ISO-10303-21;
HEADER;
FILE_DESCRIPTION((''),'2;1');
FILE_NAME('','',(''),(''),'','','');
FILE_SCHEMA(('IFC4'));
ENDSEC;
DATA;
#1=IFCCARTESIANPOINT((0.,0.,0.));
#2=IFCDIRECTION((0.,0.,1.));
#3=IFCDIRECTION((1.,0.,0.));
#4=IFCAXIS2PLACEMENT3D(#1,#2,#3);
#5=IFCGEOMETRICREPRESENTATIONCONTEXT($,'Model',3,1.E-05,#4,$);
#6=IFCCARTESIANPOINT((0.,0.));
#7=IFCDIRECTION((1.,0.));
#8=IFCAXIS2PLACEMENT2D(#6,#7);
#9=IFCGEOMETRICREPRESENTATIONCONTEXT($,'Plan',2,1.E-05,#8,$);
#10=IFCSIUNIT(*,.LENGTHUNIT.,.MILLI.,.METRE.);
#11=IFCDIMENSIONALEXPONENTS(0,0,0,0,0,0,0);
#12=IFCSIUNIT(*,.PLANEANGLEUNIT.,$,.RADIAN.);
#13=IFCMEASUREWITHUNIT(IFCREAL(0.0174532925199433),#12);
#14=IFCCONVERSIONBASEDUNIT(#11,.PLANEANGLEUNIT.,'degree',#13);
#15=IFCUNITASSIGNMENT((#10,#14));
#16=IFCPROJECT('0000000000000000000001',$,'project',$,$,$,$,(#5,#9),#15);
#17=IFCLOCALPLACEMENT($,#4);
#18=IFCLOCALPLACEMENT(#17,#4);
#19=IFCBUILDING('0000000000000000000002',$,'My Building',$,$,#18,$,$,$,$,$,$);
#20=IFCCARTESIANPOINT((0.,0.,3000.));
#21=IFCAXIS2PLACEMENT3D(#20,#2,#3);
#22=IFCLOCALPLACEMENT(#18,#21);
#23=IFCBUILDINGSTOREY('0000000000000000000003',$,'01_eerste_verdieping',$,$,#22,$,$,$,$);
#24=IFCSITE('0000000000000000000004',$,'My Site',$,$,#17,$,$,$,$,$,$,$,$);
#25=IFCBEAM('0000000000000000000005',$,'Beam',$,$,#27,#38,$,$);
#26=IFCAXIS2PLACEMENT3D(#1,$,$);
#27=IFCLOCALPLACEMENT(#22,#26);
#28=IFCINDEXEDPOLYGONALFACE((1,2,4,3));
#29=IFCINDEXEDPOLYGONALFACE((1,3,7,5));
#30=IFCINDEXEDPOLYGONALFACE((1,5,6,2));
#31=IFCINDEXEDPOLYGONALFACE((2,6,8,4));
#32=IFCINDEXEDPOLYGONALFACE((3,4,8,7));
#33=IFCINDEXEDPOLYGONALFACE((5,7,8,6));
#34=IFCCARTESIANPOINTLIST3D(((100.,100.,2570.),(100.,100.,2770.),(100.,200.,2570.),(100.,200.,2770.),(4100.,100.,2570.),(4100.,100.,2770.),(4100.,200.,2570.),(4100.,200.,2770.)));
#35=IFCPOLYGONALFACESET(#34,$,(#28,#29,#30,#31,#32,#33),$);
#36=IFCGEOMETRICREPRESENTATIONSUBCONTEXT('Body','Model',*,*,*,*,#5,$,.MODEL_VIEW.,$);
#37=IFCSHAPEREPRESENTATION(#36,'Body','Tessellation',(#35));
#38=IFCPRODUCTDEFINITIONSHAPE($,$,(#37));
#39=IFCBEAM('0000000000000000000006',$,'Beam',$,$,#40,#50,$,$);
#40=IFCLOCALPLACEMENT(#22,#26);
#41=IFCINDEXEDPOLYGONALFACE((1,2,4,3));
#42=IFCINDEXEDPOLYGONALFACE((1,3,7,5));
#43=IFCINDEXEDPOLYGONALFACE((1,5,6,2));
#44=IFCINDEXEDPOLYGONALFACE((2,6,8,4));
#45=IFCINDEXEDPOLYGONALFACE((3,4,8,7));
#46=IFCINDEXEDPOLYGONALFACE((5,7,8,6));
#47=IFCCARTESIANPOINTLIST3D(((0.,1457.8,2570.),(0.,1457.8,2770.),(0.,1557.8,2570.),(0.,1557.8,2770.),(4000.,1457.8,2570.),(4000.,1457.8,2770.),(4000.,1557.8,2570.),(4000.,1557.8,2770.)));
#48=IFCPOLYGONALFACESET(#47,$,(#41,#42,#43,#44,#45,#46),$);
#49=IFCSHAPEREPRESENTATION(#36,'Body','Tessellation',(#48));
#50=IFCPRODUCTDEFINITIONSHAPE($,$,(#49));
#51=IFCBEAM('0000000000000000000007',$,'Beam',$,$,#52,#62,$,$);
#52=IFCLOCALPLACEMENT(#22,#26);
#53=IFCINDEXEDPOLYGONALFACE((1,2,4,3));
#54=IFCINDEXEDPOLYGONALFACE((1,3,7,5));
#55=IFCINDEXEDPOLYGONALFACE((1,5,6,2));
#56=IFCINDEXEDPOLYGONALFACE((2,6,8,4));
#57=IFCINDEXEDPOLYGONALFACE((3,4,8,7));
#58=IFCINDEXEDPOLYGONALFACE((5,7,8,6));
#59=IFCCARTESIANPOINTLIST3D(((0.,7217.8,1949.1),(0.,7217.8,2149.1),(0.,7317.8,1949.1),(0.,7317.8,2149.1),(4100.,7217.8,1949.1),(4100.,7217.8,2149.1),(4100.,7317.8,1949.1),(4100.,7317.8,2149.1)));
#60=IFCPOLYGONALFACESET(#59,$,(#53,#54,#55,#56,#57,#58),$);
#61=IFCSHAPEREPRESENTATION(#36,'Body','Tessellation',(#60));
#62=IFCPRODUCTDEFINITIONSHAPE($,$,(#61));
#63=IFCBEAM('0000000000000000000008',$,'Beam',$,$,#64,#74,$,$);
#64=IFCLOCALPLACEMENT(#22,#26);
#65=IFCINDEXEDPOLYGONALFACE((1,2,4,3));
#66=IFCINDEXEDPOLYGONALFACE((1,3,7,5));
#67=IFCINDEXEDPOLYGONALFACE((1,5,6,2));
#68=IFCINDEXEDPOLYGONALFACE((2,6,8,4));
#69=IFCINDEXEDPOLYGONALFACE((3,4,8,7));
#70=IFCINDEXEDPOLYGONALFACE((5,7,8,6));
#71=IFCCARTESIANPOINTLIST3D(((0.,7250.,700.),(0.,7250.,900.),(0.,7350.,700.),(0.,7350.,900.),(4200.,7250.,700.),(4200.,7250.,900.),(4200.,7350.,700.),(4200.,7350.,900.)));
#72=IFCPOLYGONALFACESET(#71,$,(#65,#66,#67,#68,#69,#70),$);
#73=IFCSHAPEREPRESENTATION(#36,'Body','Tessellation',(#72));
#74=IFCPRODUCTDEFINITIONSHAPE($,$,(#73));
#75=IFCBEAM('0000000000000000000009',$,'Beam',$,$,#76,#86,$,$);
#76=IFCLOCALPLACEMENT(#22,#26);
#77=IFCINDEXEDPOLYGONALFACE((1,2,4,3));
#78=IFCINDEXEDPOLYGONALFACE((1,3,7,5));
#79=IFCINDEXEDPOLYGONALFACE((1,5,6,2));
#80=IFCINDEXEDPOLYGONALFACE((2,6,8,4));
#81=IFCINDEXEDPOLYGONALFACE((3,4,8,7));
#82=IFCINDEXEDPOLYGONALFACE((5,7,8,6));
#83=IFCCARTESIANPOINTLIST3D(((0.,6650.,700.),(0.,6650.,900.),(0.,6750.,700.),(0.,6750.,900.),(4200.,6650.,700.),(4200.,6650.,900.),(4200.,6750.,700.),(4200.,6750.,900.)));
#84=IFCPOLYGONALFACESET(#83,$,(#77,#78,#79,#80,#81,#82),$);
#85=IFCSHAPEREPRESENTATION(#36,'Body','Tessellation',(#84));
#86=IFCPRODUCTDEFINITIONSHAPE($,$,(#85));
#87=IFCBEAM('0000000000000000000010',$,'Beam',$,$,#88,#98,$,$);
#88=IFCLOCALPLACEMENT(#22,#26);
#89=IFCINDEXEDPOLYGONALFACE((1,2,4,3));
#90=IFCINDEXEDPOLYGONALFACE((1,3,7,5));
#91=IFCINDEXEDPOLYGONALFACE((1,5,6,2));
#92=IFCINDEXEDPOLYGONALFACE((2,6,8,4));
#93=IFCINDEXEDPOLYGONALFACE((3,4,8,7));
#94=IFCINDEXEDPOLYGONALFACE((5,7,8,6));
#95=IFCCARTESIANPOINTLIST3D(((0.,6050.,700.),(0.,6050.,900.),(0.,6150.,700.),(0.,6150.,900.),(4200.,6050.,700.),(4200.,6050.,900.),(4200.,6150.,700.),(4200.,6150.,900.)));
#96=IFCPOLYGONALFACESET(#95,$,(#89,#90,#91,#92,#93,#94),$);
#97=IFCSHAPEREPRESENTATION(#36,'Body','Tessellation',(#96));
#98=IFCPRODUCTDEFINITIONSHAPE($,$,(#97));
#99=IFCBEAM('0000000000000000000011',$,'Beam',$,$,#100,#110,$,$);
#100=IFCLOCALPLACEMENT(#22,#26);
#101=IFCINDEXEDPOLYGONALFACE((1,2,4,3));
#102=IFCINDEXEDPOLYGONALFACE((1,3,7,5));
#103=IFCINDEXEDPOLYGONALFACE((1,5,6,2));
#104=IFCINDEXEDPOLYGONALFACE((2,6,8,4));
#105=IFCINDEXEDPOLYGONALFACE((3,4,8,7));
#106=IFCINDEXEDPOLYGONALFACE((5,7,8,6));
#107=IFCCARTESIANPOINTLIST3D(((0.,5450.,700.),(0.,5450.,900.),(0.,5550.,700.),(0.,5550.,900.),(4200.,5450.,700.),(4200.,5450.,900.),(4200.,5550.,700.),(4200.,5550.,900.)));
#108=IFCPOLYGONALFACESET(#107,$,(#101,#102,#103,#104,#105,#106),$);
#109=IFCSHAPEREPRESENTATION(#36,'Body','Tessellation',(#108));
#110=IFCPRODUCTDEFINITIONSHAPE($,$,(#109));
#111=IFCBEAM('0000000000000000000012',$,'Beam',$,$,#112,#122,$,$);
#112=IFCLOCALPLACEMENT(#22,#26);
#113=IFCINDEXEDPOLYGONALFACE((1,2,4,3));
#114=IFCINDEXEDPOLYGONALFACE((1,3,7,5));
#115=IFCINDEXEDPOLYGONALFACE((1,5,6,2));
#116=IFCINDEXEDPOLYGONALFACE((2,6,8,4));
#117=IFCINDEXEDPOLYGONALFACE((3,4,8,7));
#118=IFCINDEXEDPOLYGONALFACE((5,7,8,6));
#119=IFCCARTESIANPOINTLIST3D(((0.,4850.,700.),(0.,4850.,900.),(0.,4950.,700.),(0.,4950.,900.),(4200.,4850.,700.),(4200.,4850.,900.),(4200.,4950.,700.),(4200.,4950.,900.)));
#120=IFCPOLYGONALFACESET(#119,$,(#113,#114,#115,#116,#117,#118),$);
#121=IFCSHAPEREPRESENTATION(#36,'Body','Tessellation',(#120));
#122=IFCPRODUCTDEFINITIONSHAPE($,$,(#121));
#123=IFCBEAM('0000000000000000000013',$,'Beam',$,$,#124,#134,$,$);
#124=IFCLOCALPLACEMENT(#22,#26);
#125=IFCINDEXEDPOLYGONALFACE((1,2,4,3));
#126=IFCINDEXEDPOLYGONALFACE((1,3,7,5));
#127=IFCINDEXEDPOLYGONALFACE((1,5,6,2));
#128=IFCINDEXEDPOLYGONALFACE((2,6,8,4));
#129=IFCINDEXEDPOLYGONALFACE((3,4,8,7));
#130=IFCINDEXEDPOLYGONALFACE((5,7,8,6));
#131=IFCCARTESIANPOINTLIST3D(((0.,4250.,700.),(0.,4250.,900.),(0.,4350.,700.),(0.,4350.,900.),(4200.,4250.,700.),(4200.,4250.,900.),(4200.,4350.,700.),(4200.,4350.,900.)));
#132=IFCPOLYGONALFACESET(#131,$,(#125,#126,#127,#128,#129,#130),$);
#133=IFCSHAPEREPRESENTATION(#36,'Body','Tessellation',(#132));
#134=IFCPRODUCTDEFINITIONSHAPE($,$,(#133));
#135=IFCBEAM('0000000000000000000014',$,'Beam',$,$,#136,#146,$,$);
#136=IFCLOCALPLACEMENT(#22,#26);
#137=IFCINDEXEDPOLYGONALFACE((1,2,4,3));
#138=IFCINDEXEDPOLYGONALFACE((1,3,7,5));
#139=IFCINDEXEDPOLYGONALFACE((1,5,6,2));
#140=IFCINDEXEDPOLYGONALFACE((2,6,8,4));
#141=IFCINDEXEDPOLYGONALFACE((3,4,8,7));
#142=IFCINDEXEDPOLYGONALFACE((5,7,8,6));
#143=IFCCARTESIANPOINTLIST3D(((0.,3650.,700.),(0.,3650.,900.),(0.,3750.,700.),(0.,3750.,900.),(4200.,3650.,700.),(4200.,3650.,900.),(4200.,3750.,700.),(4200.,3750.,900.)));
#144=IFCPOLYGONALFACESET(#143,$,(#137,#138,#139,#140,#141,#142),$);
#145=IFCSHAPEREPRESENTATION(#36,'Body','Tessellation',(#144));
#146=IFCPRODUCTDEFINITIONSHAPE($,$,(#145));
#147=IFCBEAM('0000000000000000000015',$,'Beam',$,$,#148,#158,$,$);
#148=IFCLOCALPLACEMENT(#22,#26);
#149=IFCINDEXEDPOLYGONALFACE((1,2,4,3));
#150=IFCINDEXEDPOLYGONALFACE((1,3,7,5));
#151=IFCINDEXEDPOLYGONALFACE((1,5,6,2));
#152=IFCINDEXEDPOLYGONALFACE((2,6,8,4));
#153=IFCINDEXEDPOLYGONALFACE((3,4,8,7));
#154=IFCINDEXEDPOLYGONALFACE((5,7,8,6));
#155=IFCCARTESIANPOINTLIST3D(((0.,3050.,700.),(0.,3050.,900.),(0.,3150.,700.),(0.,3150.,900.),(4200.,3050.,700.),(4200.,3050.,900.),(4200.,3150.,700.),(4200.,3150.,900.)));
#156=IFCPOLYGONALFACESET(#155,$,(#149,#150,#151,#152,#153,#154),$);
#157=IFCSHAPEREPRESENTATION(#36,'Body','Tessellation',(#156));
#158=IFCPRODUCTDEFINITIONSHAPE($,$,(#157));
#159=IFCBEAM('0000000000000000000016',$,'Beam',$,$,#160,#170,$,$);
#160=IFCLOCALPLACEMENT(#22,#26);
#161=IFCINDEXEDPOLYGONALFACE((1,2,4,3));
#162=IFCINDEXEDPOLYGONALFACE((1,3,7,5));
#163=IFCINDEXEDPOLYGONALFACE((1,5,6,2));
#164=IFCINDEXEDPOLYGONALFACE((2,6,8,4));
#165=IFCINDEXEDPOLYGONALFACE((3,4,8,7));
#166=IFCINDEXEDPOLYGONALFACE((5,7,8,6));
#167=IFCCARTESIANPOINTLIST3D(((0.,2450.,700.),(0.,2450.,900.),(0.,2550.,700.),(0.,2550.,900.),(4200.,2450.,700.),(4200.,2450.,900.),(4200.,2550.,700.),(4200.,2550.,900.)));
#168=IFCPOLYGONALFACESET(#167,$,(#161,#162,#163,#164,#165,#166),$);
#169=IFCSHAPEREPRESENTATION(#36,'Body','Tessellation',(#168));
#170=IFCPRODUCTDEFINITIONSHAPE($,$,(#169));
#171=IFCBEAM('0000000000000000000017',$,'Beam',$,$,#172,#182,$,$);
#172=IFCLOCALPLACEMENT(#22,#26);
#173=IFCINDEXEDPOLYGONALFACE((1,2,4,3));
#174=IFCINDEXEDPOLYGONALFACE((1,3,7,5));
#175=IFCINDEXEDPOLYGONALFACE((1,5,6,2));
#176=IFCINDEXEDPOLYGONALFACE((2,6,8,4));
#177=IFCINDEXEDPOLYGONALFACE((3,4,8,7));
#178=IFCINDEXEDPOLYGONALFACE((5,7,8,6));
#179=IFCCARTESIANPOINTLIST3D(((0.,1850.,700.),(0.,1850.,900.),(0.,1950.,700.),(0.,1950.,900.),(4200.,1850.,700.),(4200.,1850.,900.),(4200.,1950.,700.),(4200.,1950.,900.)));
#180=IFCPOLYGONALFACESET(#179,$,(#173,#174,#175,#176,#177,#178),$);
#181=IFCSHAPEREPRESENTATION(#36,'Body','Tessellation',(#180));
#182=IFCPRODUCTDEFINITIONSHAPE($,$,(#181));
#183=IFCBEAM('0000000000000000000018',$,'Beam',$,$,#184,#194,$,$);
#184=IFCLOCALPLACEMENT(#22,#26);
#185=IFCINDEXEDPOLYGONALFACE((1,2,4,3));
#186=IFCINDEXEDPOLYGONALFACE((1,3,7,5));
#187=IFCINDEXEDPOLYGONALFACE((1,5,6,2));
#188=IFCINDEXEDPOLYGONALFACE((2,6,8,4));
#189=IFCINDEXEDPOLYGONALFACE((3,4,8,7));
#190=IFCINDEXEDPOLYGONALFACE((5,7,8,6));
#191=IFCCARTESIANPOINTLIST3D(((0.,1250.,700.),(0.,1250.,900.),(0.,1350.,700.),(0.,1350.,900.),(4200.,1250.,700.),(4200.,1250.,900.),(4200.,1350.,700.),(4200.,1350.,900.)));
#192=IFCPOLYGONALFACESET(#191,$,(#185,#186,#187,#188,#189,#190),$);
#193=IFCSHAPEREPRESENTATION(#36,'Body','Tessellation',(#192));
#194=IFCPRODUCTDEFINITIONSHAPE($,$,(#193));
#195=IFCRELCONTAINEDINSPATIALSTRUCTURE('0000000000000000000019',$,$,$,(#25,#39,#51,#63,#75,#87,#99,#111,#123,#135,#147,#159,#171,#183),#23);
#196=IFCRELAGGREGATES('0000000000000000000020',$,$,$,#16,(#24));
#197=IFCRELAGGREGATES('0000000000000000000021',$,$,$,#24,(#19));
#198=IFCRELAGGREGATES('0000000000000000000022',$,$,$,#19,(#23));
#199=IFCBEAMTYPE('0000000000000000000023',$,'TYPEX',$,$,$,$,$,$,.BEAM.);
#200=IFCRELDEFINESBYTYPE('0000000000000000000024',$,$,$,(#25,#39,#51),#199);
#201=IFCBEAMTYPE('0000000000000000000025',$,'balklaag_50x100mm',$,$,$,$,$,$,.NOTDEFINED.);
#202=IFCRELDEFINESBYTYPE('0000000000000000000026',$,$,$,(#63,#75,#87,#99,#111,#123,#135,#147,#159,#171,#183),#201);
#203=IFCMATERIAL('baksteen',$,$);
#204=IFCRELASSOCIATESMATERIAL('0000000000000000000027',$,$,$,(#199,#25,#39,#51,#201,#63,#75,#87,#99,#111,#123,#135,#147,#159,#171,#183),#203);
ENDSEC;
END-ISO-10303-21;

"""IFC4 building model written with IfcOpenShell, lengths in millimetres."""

from ifc_helpers import new_model, entity, si_unit, converted_unit, frame, origin_with_axes, origin_2d_with_axis, place, context, subcontext, project, spatial, rectangle, extrude, material, material_profile, profile_set, profile_usage, type_object, element, save


model = new_model("IFC4")

# Units and contexts
model_context = context("Model", 3, precision=1e-05, world=origin_with_axes())
plan_context = context("Plan", 2, precision=1e-05, world=origin_2d_with_axis())
body_context = subcontext(model_context, "Body", "Model", "MODEL_VIEW")
ifc_project = project(units=[si_unit("LENGTHUNIT", "METRE", prefix="MILLI"), converted_unit("PLANEANGLEUNIT", "degree", entity("IfcReal", 0.0174532925199433), si_unit("PLANEANGLEUNIT", "RADIAN"), dimensions=[0, 0, 0, 0, 0, 0, 0])], contexts=[model_context, plan_context])

# Site, building, storey
site_placement = place(None, origin_with_axes())
site = spatial("IfcSite", under=ifc_project, at=site_placement, Name="My Site")
building_placement = place(site_placement, origin_with_axes())
building = spatial("IfcBuilding", under=site, at=building_placement, Name="My Building")
storey_placement = place(building_placement, frame((0.0, 0.0, 3000.0), z_axis=(0.0, 0.0, 1.0), x_axis=(1.0, 0.0, 0.0)))
storey = spatial("IfcBuildingStorey", under=building, at=storey_placement, Name="01_eerste_verdieping")

# Beams
ifc_material = material(Name="baksteen")
ifc_material_profile_1 = material_profile(ifc_material, rectangle(XDim=100.0, YDim=200.0))
ifc_profile_set_1 = profile_set([ifc_material_profile_1])
ifc_profile_usage_1 = profile_usage(ifc_profile_set_1, cardinal=5)
beam_type_1 = type_object("IfcBeamType", Name="TYPEX", PredefinedType="BEAM", material=ifc_profile_set_1)
beam_1_placement = place(storey_placement, frame((100.0, 150.0, 2670.0), z_axis=(1.0, 0.0, 0.0), x_axis=(0.0, 1.0, 0.0)))
element("IfcBeam", 1, at=beam_1_placement, inside=storey, type_object=beam_type_1, material=ifc_profile_usage_1, Name="Beam", context=body_context, shape_type="SweptSolid", body=[
    extrude(rectangle(XDim=100.0, YDim=200.0), origin_with_axes(), (0.0, 0.0, 1.0), 4000.0),
])
ifc_profile_usage_2 = profile_usage(ifc_profile_set_1, cardinal=5)
beam_2_placement = place(storey_placement, frame((0.0, 1507.8, 2670.0), z_axis=(1.0, 0.0, 0.0), x_axis=(0.0, 1.0, 0.0)))
element("IfcBeam", 2, at=beam_2_placement, inside=storey, type_object=beam_type_1, material=ifc_profile_usage_2, Name="Beam", context=body_context, shape_type="SweptSolid", body=[
    extrude(rectangle(XDim=100.0, YDim=200.0), origin_with_axes(), (0.0, 0.0, 1.0), 4000.0),
])
ifc_profile_usage_3 = profile_usage(ifc_profile_set_1, cardinal=5)
beam_3_placement = place(storey_placement, frame((0.0, 7267.8, 2049.1), z_axis=(1.0, 0.0, 0.0), x_axis=(0.0, 1.0, 0.0)))
element("IfcBeam", 3, at=beam_3_placement, inside=storey, type_object=beam_type_1, material=ifc_profile_usage_3, Name="Beam", context=body_context, shape_type="SweptSolid", body=[
    extrude(rectangle(XDim=100.0, YDim=200.0), origin_with_axes(), (0.0, 0.0, 1.0), 4100.0),
])
ifc_material_profile_2 = material_profile(ifc_material, rectangle(XDim=100.0, YDim=200.0))
ifc_profile_set_2 = profile_set([ifc_material_profile_2])
ifc_profile_usage_4 = profile_usage(ifc_profile_set_2, cardinal=5)
beam_type_2 = type_object("IfcBeamType", Name="balklaag_50x100mm", PredefinedType="NOTDEFINED", material=ifc_profile_set_2)
beam_4_placement = place(storey_placement, frame((4200.0, 7300.0, 800.0), z_axis=(-1.0, 0.0, 0.0), x_axis=(0.0, -1.0, 0.0)))
element("IfcBeam", 4, at=beam_4_placement, inside=storey, type_object=beam_type_2, material=ifc_profile_usage_4, Name="Beam", context=body_context, shape_type="SweptSolid", body=[
    extrude(rectangle(XDim=100.0, YDim=200.0), origin_with_axes(), (0.0, 0.0, 1.0), 4200.0),
])
ifc_profile_usage_5 = profile_usage(ifc_profile_set_2, cardinal=5)
beam_5_placement = place(storey_placement, frame((4200.0, 6700.0, 800.0), z_axis=(-1.0, 0.0, 0.0), x_axis=(0.0, -1.0, 0.0)))
element("IfcBeam", 5, at=beam_5_placement, inside=storey, type_object=beam_type_2, material=ifc_profile_usage_5, Name="Beam", context=body_context, shape_type="SweptSolid", body=[
    extrude(rectangle(XDim=100.0, YDim=200.0), origin_with_axes(), (0.0, 0.0, 1.0), 4200.0),
])
ifc_profile_usage_6 = profile_usage(ifc_profile_set_2, cardinal=5)
beam_6_placement = place(storey_placement, frame((4200.0, 6100.0, 800.0), z_axis=(-1.0, 0.0, 0.0), x_axis=(0.0, -1.0, 0.0)))
element("IfcBeam", 6, at=beam_6_placement, inside=storey, type_object=beam_type_2, material=ifc_profile_usage_6, Name="Beam", context=body_context, shape_type="SweptSolid", body=[
    extrude(rectangle(XDim=100.0, YDim=200.0), origin_with_axes(), (0.0, 0.0, 1.0), 4200.0),
])
ifc_profile_usage_7 = profile_usage(ifc_profile_set_2, cardinal=5)
beam_7_placement = place(storey_placement, frame((4200.0, 5500.0, 800.0), z_axis=(-1.0, 0.0, 0.0), x_axis=(0.0, -1.0, 0.0)))
element("IfcBeam", 7, at=beam_7_placement, inside=storey, type_object=beam_type_2, material=ifc_profile_usage_7, Name="Beam", context=body_context, shape_type="SweptSolid", body=[
    extrude(rectangle(XDim=100.0, YDim=200.0), origin_with_axes(), (0.0, 0.0, 1.0), 4200.0),
])
ifc_profile_usage_8 = profile_usage(ifc_profile_set_2, cardinal=5)
beam_8_placement = place(storey_placement, frame((4200.0, 4900.0, 800.0), z_axis=(-1.0, 0.0, 0.0), x_axis=(0.0, -1.0, 0.0)))
element("IfcBeam", 8, at=beam_8_placement, inside=storey, type_object=beam_type_2, material=ifc_profile_usage_8, Name="Beam", context=body_context, shape_type="SweptSolid", body=[
    extrude(rectangle(XDim=100.0, YDim=200.0), origin_with_axes(), (0.0, 0.0, 1.0), 4200.0),
])
ifc_profile_usage_9 = profile_usage(ifc_profile_set_2, cardinal=5)
beam_9_placement = place(storey_placement, frame((4200.0, 4300.0, 800.0), z_axis=(-1.0, 0.0, 0.0), x_axis=(0.0, -1.0, 0.0)))
element("IfcBeam", 9, at=beam_9_placement, inside=storey, type_object=beam_type_2, material=ifc_profile_usage_9, Name="Beam", context=body_context, shape_type="SweptSolid", body=[
    extrude(rectangle(XDim=100.0, YDim=200.0), origin_with_axes(), (0.0, 0.0, 1.0), 4200.0),
])
ifc_profile_usage_10 = profile_usage(ifc_profile_set_2, cardinal=5)
beam_10_placement = place(storey_placement, frame((4200.0, 3700.0, 800.0), z_axis=(-1.0, 0.0, 0.0), x_axis=(0.0, -1.0, 0.0)))
element("IfcBeam", 10, at=beam_10_placement, inside=storey, type_object=beam_type_2, material=ifc_profile_usage_10, Name="Beam", context=body_context, shape_type="SweptSolid", body=[
    extrude(rectangle(XDim=100.0, YDim=200.0), origin_with_axes(), (0.0, 0.0, 1.0), 4200.0),
])
ifc_profile_usage_11 = profile_usage(ifc_profile_set_2, cardinal=5)
beam_11_placement = place(storey_placement, frame((4200.0, 3100.0, 800.0), z_axis=(-1.0, 0.0, 0.0), x_axis=(0.0, -1.0, 0.0)))
element("IfcBeam", 11, at=beam_11_placement, inside=storey, type_object=beam_type_2, material=ifc_profile_usage_11, Name="Beam", context=body_context, shape_type="SweptSolid", body=[
    extrude(rectangle(XDim=100.0, YDim=200.0), origin_with_axes(), (0.0, 0.0, 1.0), 4200.0),
])
ifc_profile_usage_12 = profile_usage(ifc_profile_set_2, cardinal=5)
beam_12_placement = place(storey_placement, frame((4200.0, 2500.0, 800.0), z_axis=(-1.0, 0.0, 0.0), x_axis=(0.0, -1.0, 0.0)))
element("IfcBeam", 12, at=beam_12_placement, inside=storey, type_object=beam_type_2, material=ifc_profile_usage_12, Name="Beam", context=body_context, shape_type="SweptSolid", body=[
    extrude(rectangle(XDim=100.0, YDim=200.0), origin_with_axes(), (0.0, 0.0, 1.0), 4200.0),
])
ifc_profile_usage_13 = profile_usage(ifc_profile_set_2, cardinal=5)
beam_13_placement = place(storey_placement, frame((4200.0, 1900.0, 800.0), z_axis=(-1.0, 0.0, 0.0), x_axis=(0.0, -1.0, 0.0)))
element("IfcBeam", 13, at=beam_13_placement, inside=storey, type_object=beam_type_2, material=ifc_profile_usage_13, Name="Beam", context=body_context, shape_type="SweptSolid", body=[
    extrude(rectangle(XDim=100.0, YDim=200.0), origin_with_axes(), (0.0, 0.0, 1.0), 4200.0),
])
ifc_profile_usage_14 = profile_usage(ifc_profile_set_2, cardinal=5)
beam_14_placement = place(storey_placement, frame((4200.0, 1300.0, 800.0), z_axis=(-1.0, 0.0, 0.0), x_axis=(0.0, -1.0, 0.0)))
element("IfcBeam", 14, at=beam_14_placement, inside=storey, type_object=beam_type_2, material=ifc_profile_usage_14, Name="Beam", context=body_context, shape_type="SweptSolid", body=[
    extrude(rectangle(XDim=100.0, YDim=200.0), origin_with_axes(), (0.0, 0.0, 1.0), 4200.0),
])

save(model, "model.ifc")
